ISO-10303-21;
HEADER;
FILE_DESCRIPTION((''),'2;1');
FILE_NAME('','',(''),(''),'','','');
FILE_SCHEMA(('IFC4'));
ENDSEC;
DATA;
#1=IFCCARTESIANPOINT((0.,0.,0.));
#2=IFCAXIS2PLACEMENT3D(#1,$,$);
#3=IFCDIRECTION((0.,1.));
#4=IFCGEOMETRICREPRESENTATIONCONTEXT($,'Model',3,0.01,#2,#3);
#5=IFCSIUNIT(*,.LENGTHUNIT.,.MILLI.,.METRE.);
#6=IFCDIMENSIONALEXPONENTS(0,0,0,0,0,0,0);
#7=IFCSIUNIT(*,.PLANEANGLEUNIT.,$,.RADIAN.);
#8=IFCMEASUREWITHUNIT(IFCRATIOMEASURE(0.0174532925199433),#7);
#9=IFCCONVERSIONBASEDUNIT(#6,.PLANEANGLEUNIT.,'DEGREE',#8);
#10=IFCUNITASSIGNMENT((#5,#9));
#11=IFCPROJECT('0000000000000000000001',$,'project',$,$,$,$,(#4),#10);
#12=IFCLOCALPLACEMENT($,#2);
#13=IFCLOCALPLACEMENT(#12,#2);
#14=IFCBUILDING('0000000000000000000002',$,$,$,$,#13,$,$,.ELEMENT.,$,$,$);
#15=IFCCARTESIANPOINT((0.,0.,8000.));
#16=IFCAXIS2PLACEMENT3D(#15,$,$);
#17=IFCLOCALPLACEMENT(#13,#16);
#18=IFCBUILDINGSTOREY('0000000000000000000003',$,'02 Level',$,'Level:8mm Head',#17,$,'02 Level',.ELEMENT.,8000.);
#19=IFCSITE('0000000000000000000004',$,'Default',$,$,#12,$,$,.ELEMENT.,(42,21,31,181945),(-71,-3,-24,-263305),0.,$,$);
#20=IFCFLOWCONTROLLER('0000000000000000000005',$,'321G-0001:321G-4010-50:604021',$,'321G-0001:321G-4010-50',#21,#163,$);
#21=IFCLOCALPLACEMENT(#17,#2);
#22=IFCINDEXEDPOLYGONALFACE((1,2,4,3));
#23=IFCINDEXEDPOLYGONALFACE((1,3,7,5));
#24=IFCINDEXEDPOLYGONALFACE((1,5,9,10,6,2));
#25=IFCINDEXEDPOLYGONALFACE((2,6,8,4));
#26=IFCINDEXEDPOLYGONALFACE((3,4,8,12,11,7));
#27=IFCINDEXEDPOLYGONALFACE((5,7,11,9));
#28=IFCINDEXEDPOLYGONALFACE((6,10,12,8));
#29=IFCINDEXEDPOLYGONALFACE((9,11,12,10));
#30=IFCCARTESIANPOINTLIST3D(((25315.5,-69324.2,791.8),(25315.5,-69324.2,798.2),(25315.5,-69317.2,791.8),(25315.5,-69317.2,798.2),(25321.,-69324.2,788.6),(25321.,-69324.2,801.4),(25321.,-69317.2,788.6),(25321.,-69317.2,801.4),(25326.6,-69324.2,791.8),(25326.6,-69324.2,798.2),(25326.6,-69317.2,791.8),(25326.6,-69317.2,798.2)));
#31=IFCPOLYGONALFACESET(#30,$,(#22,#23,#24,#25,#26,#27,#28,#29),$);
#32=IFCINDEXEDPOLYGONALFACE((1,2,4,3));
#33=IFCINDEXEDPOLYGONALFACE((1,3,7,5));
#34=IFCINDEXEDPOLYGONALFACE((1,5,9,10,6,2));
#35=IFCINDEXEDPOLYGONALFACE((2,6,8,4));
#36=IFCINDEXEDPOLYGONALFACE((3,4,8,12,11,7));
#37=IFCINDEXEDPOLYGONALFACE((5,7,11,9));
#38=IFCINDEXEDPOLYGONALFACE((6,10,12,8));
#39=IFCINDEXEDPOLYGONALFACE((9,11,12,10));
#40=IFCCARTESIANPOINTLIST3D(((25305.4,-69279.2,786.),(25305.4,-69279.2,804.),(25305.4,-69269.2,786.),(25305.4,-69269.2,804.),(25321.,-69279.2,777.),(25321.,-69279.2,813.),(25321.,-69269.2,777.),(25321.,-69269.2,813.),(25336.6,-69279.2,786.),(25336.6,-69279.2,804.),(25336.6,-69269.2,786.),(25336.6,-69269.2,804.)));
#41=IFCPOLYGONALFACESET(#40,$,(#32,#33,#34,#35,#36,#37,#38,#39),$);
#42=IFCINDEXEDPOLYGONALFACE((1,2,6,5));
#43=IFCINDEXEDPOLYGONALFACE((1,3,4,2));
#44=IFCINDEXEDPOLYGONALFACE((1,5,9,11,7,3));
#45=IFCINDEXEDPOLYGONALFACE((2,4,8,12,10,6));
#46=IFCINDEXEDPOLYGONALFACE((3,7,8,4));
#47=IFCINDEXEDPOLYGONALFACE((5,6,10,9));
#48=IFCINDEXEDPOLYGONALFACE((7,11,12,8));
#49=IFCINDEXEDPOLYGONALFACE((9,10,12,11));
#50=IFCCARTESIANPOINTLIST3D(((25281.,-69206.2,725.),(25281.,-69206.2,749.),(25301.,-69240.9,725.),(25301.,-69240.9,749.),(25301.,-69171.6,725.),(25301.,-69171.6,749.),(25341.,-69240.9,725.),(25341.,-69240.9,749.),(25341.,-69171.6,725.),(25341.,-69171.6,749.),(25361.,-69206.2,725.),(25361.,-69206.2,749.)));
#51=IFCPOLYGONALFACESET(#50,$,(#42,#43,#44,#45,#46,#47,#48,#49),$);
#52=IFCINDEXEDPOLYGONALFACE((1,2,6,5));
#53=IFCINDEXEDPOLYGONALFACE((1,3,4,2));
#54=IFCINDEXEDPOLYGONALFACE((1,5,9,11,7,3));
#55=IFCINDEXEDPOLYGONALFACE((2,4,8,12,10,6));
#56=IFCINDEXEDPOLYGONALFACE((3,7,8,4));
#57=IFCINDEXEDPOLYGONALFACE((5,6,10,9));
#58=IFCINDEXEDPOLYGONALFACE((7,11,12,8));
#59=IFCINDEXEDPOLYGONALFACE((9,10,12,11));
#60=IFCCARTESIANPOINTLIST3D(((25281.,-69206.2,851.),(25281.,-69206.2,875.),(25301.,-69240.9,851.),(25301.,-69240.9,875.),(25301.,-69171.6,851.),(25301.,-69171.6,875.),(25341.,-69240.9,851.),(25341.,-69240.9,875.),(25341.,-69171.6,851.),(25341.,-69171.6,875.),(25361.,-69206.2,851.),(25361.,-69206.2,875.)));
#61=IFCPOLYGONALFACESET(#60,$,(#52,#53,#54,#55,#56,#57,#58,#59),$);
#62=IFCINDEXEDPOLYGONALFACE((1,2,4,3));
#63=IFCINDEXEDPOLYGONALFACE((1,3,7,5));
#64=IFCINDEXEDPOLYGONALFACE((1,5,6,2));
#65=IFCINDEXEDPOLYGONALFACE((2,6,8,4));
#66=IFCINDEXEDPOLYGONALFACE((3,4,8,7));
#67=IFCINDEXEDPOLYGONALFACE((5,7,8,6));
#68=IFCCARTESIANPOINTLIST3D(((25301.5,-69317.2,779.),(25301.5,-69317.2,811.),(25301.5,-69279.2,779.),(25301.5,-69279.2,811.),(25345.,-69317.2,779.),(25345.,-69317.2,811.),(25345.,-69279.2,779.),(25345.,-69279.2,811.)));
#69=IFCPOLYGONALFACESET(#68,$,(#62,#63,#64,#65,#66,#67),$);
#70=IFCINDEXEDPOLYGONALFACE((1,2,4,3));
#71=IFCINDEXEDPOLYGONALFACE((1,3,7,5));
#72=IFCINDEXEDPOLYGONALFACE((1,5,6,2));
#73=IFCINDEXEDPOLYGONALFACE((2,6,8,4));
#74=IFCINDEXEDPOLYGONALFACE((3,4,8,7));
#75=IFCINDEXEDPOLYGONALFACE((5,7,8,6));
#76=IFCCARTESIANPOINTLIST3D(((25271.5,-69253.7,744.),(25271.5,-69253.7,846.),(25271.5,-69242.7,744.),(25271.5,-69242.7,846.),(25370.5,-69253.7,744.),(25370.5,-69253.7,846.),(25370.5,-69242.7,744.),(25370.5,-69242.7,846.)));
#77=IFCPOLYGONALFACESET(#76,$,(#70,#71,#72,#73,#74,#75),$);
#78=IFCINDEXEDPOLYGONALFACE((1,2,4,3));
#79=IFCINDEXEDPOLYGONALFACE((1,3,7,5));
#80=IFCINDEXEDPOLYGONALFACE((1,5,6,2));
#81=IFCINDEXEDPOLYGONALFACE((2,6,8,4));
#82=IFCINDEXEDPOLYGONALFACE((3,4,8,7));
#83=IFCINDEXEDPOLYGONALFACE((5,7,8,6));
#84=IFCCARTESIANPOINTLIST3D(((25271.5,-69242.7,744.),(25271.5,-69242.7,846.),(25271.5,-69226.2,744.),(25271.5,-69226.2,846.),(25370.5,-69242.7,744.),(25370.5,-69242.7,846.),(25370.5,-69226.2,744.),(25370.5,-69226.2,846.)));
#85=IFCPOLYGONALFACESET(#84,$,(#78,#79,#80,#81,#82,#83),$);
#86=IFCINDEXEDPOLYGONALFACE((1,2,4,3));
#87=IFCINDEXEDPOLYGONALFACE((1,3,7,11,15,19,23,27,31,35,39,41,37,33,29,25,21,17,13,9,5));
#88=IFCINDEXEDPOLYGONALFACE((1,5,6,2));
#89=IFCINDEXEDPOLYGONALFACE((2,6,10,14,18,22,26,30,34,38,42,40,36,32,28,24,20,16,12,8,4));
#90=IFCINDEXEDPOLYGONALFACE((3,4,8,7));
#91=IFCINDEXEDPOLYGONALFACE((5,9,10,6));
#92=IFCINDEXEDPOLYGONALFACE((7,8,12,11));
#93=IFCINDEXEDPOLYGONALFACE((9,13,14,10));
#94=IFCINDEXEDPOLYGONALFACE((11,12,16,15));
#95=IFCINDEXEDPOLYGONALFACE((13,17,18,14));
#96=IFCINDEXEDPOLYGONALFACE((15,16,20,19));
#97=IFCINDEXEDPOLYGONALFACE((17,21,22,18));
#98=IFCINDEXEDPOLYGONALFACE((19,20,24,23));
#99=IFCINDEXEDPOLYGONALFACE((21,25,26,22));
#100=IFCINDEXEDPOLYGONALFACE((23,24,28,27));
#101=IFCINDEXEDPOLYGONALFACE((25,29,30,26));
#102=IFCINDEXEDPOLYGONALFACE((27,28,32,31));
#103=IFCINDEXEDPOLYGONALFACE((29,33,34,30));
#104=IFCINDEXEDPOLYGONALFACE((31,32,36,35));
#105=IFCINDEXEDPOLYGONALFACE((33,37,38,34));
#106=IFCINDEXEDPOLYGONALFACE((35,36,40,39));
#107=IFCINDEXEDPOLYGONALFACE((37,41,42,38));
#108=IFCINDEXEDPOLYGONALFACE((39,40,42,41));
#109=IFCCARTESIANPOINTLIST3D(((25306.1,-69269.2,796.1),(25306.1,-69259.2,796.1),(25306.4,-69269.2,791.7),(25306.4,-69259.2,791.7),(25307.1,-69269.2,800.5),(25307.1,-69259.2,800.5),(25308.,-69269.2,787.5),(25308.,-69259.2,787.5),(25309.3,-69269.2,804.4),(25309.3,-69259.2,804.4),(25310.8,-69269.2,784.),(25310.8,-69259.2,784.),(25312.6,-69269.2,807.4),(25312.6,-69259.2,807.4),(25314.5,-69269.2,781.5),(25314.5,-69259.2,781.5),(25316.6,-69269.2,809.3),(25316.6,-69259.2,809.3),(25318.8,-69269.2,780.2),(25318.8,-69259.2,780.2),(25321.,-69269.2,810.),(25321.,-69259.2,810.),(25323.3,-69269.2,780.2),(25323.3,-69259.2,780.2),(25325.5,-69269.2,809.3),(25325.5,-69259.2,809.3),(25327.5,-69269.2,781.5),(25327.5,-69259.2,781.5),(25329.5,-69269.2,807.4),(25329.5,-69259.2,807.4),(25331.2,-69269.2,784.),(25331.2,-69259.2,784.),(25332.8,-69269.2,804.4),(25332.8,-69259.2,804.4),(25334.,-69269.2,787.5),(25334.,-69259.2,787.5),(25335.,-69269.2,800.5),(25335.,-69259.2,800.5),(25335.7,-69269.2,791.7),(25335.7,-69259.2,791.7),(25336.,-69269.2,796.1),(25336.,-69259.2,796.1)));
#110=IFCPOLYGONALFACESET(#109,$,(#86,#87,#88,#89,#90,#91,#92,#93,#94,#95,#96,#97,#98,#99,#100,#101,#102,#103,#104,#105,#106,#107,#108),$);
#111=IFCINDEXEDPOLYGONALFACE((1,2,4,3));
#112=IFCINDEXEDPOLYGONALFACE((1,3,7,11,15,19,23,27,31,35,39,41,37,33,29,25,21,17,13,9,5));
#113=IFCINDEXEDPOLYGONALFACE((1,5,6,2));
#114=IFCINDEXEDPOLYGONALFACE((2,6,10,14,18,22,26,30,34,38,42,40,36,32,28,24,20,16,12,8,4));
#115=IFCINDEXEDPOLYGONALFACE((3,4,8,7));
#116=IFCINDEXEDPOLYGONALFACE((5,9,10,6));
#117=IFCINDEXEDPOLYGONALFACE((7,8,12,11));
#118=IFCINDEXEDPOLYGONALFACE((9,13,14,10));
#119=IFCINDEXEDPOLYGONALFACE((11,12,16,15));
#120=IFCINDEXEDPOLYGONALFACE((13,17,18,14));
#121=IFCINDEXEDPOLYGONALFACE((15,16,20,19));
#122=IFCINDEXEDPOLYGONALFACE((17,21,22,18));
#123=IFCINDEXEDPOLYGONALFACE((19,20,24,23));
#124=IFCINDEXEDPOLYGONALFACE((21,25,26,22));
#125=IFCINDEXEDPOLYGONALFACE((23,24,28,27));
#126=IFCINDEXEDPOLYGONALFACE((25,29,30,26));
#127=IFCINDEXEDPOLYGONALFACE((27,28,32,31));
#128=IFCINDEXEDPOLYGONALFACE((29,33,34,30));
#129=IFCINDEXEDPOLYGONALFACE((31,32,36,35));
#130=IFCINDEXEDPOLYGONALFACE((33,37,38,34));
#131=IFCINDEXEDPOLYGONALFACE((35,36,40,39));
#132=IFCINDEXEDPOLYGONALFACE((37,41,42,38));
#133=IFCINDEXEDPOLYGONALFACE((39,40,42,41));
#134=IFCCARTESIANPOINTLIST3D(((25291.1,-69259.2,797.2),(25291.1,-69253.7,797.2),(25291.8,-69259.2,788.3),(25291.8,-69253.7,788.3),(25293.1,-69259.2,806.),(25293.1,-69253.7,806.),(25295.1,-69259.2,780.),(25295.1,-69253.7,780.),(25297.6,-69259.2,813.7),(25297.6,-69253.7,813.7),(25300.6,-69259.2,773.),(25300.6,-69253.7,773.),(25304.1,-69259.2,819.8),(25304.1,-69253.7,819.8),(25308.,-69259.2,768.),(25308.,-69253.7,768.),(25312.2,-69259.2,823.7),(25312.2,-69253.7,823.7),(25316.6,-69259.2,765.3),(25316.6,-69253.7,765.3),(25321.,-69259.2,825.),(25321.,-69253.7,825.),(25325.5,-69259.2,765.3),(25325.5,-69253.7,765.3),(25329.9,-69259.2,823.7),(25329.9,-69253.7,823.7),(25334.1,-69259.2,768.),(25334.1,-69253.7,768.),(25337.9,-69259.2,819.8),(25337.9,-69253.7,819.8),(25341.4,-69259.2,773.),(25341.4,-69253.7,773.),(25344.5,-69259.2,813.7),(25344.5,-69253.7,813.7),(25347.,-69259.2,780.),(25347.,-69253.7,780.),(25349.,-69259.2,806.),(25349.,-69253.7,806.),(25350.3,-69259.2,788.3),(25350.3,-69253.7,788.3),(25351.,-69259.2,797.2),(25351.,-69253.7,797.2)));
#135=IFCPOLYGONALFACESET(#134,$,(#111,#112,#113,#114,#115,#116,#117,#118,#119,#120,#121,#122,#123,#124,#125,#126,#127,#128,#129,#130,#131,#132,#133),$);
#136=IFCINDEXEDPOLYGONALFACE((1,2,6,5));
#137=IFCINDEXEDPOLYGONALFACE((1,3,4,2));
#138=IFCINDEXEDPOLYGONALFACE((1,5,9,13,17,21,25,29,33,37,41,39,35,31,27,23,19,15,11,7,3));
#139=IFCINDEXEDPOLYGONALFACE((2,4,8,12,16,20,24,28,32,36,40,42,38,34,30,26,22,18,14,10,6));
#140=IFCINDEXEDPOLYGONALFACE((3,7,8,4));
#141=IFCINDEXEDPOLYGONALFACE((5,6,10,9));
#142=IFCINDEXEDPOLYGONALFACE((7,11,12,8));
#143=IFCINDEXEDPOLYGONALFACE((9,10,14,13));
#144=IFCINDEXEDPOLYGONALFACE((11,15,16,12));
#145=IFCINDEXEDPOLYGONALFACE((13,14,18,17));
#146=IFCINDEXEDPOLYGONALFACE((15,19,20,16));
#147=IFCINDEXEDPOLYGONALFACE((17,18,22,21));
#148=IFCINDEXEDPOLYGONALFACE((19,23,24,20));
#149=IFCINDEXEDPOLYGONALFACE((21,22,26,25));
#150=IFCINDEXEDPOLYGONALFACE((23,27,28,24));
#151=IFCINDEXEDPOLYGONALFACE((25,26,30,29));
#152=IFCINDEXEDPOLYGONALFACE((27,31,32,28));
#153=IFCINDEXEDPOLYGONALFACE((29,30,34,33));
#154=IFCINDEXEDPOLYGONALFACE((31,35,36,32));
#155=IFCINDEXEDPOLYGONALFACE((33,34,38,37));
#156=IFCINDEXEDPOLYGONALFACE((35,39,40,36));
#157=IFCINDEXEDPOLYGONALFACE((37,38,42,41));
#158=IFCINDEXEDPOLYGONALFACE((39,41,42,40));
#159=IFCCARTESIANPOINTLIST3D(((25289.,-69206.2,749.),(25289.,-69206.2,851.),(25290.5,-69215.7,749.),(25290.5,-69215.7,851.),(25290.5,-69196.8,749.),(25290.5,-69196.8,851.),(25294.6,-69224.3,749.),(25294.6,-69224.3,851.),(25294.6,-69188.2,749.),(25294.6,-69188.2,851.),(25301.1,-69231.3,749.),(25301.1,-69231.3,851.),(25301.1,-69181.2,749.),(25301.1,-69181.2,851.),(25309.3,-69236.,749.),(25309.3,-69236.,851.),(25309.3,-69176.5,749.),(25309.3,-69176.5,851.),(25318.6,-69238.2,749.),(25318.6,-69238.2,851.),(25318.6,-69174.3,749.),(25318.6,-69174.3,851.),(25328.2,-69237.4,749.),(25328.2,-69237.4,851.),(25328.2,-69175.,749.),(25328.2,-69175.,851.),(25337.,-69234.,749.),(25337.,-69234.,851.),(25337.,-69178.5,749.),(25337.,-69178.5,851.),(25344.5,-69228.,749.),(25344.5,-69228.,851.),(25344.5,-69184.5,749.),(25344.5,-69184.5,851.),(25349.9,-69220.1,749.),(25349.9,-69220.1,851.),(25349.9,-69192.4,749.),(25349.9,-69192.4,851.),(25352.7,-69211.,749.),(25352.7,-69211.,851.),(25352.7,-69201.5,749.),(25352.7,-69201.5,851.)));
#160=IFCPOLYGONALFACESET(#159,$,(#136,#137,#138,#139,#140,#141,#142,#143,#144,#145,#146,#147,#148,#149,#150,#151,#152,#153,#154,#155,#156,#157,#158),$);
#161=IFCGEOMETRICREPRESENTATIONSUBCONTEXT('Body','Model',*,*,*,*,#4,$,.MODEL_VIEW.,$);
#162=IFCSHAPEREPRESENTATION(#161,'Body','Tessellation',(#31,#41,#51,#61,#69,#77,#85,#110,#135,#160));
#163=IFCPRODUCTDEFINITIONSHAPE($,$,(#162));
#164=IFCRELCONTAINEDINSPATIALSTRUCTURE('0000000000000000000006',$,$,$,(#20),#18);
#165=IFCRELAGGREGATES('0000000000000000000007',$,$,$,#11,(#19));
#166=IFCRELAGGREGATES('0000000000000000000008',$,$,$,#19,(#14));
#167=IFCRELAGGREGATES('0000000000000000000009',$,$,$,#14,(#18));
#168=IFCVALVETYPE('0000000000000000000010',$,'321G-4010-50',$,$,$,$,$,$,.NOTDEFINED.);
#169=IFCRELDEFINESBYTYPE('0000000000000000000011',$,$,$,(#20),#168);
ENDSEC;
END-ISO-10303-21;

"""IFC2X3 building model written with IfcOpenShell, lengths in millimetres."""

from ifc_helpers import new_model, entity, si_unit, converted_unit, direction, frame, frame_2d, origin, origin_2d_with_axis, place, context, subcontext, project, spatial, polyline, rectangle, circle, outline, extrude, source, transform, mapped, type_object, type_shapes, element, save


model = new_model("IFC2X3")

# Units and contexts
model_context = context("Model", 3, precision=0.01, world=origin(), true_north=direction((0.0, 1.0)))
body_context = subcontext(model_context, "Body", "Model", "MODEL_VIEW")
ifc_project = project(units=[si_unit("LENGTHUNIT", "METRE", prefix="MILLI"), converted_unit("PLANEANGLEUNIT", "DEGREE", entity("IfcRatioMeasure", 0.0174532925199433), si_unit("PLANEANGLEUNIT", "RADIAN"), dimensions=[0, 0, 0, 0, 0, 0, 0])], contexts=[model_context])

# Site, building, storey
site_placement = place(None, origin())
site = spatial("IfcSite", under=ifc_project, at=site_placement, Name="Default", CompositionType="ELEMENT", RefLatitude=(42, 21, 31, 181945), RefLongitude=(-71, -3, -24, -263305), RefElevation=0.0)
building_placement = place(site_placement, origin())
building = spatial("IfcBuilding", under=site, at=building_placement, CompositionType="ELEMENT")
storey_placement = place(building_placement, frame((0.0, 0.0, 8000.0)))
storey = spatial("IfcBuildingStorey", under=building, at=storey_placement, Name="02 Level", ObjectType="Level:8mm Head", LongName="02 Level", CompositionType="ELEMENT", Elevation=8000.0)

# Flow controller
valve_type_1 = type_object("IfcValveType", Name="321G-4010-50", PredefinedType="NOTDEFINED")
shared_shape_1 = source(origin(), body_context, "Body", "SweptSolid", [
    extrude(outline(polyline([(-3.2, -5.5), (3.2, -5.5), (6.4, 0.0), (3.2, 5.5), (-3.2, 5.5), (-6.4, 0.0), (-3.2, -5.5)])), frame((-5.0, 0.0, 111.0), z_axis=(0.0, 0.0, 1.0), x_axis=(-1.0, 0.0, 0.0)), (0.0, 0.0, 1.0), 7.0),
    extrude(outline(polyline([(-9.0, -15.6), (9.0, -15.6), (18.0, 0.0), (9.0, 15.6), (-9.0, 15.6), (-18.0, 0.0), (-9.0, -15.6)])), frame((-5.0, 0.0, 63.0), z_axis=(0.0, 0.0, 1.0), x_axis=(-1.0, 0.0, 0.0)), (0.0, 0.0, 1.0), 10.0),
    extrude(outline(polyline([(-20.0, -34.6), (20.0, -34.6), (40.0, 0.0), (20.0, 34.6), (-20.0, 34.6), (-40.0, 0.0), (-20.0, -34.6)])), frame((-75.0, 0.0, 0.0), z_axis=(1.0, 0.0, 0.0), x_axis=(0.0, -1.0, 0.0)), (0.0, 0.0, 1.0), 24.0),
    extrude(outline(polyline([(-20.0, -34.6), (20.0, -34.6), (40.0, 0.0), (20.0, 34.6), (-20.0, 34.6), (-40.0, 0.0), (-20.0, -34.6)])), frame((51.0, 0.0, 0.0), z_axis=(1.0, 0.0, 0.0), x_axis=(0.0, -1.0, 0.0)), (0.0, 0.0, 1.0), 24.0),
    extrude(rectangle(XDim=32.0, YDim=43.5, at=origin_2d_with_axis()), frame((-5.0, -2.2, 73.0)), (0.0, 0.0, 1.0), 38.0),
    extrude(rectangle(XDim=102.0, YDim=99.0, at=origin_2d_with_axis()), frame((-5.0, 0.0, 36.5)), (0.0, 0.0, 1.0), 11.0),
    extrude(rectangle(XDim=102.0, YDim=99.0, at=origin_2d_with_axis()), frame((-5.0, 0.0, 20.0)), (0.0, 0.0, 1.0), 16.5),
    extrude(circle(Radius=15.0, at=frame_2d((0.0, 0.0), x_axis=(1.0, 0.0))), frame((-5.0, 0.0, 53.0)), (0.0, 0.0, 1.0), 10.0),
    extrude(circle(Radius=30.0, at=frame_2d((0.0, 0.0), x_axis=(1.0, 0.0))), frame((-5.0, 0.0, 47.5)), (0.0, 0.0, 1.0), 5.5),
    extrude(circle(Radius=32.0, at=frame_2d((0.0, 0.0), x_axis=(1.0, 0.0))), frame((-51.0, 0.0, 0.0), z_axis=(1.0, 0.0, 0.0), x_axis=(0.0, 1.0, 0.0)), (0.0, 0.0, 1.0), 102.0),
])
type_shapes(valve_type_1, [shared_shape_1])
flow_controller_1_placement = place(storey_placement, frame((25321.0, -69206.2, 800.0), z_axis=(0.0, -1.0, 0.0), x_axis=(0.0, 0.0, 1.0)))
element("IfcFlowController", 1, at=flow_controller_1_placement, inside=storey, type_object=valve_type_1, Name="321G-0001:321G-4010-50:604021", ObjectType="321G-0001:321G-4010-50", context=body_context, shape_type="MappedRepresentation", body=[
    mapped(shared_shape_1, transform((0.0, 0.0, 0.0), scale=1.0)),
])

save(model, "model.ifc")
